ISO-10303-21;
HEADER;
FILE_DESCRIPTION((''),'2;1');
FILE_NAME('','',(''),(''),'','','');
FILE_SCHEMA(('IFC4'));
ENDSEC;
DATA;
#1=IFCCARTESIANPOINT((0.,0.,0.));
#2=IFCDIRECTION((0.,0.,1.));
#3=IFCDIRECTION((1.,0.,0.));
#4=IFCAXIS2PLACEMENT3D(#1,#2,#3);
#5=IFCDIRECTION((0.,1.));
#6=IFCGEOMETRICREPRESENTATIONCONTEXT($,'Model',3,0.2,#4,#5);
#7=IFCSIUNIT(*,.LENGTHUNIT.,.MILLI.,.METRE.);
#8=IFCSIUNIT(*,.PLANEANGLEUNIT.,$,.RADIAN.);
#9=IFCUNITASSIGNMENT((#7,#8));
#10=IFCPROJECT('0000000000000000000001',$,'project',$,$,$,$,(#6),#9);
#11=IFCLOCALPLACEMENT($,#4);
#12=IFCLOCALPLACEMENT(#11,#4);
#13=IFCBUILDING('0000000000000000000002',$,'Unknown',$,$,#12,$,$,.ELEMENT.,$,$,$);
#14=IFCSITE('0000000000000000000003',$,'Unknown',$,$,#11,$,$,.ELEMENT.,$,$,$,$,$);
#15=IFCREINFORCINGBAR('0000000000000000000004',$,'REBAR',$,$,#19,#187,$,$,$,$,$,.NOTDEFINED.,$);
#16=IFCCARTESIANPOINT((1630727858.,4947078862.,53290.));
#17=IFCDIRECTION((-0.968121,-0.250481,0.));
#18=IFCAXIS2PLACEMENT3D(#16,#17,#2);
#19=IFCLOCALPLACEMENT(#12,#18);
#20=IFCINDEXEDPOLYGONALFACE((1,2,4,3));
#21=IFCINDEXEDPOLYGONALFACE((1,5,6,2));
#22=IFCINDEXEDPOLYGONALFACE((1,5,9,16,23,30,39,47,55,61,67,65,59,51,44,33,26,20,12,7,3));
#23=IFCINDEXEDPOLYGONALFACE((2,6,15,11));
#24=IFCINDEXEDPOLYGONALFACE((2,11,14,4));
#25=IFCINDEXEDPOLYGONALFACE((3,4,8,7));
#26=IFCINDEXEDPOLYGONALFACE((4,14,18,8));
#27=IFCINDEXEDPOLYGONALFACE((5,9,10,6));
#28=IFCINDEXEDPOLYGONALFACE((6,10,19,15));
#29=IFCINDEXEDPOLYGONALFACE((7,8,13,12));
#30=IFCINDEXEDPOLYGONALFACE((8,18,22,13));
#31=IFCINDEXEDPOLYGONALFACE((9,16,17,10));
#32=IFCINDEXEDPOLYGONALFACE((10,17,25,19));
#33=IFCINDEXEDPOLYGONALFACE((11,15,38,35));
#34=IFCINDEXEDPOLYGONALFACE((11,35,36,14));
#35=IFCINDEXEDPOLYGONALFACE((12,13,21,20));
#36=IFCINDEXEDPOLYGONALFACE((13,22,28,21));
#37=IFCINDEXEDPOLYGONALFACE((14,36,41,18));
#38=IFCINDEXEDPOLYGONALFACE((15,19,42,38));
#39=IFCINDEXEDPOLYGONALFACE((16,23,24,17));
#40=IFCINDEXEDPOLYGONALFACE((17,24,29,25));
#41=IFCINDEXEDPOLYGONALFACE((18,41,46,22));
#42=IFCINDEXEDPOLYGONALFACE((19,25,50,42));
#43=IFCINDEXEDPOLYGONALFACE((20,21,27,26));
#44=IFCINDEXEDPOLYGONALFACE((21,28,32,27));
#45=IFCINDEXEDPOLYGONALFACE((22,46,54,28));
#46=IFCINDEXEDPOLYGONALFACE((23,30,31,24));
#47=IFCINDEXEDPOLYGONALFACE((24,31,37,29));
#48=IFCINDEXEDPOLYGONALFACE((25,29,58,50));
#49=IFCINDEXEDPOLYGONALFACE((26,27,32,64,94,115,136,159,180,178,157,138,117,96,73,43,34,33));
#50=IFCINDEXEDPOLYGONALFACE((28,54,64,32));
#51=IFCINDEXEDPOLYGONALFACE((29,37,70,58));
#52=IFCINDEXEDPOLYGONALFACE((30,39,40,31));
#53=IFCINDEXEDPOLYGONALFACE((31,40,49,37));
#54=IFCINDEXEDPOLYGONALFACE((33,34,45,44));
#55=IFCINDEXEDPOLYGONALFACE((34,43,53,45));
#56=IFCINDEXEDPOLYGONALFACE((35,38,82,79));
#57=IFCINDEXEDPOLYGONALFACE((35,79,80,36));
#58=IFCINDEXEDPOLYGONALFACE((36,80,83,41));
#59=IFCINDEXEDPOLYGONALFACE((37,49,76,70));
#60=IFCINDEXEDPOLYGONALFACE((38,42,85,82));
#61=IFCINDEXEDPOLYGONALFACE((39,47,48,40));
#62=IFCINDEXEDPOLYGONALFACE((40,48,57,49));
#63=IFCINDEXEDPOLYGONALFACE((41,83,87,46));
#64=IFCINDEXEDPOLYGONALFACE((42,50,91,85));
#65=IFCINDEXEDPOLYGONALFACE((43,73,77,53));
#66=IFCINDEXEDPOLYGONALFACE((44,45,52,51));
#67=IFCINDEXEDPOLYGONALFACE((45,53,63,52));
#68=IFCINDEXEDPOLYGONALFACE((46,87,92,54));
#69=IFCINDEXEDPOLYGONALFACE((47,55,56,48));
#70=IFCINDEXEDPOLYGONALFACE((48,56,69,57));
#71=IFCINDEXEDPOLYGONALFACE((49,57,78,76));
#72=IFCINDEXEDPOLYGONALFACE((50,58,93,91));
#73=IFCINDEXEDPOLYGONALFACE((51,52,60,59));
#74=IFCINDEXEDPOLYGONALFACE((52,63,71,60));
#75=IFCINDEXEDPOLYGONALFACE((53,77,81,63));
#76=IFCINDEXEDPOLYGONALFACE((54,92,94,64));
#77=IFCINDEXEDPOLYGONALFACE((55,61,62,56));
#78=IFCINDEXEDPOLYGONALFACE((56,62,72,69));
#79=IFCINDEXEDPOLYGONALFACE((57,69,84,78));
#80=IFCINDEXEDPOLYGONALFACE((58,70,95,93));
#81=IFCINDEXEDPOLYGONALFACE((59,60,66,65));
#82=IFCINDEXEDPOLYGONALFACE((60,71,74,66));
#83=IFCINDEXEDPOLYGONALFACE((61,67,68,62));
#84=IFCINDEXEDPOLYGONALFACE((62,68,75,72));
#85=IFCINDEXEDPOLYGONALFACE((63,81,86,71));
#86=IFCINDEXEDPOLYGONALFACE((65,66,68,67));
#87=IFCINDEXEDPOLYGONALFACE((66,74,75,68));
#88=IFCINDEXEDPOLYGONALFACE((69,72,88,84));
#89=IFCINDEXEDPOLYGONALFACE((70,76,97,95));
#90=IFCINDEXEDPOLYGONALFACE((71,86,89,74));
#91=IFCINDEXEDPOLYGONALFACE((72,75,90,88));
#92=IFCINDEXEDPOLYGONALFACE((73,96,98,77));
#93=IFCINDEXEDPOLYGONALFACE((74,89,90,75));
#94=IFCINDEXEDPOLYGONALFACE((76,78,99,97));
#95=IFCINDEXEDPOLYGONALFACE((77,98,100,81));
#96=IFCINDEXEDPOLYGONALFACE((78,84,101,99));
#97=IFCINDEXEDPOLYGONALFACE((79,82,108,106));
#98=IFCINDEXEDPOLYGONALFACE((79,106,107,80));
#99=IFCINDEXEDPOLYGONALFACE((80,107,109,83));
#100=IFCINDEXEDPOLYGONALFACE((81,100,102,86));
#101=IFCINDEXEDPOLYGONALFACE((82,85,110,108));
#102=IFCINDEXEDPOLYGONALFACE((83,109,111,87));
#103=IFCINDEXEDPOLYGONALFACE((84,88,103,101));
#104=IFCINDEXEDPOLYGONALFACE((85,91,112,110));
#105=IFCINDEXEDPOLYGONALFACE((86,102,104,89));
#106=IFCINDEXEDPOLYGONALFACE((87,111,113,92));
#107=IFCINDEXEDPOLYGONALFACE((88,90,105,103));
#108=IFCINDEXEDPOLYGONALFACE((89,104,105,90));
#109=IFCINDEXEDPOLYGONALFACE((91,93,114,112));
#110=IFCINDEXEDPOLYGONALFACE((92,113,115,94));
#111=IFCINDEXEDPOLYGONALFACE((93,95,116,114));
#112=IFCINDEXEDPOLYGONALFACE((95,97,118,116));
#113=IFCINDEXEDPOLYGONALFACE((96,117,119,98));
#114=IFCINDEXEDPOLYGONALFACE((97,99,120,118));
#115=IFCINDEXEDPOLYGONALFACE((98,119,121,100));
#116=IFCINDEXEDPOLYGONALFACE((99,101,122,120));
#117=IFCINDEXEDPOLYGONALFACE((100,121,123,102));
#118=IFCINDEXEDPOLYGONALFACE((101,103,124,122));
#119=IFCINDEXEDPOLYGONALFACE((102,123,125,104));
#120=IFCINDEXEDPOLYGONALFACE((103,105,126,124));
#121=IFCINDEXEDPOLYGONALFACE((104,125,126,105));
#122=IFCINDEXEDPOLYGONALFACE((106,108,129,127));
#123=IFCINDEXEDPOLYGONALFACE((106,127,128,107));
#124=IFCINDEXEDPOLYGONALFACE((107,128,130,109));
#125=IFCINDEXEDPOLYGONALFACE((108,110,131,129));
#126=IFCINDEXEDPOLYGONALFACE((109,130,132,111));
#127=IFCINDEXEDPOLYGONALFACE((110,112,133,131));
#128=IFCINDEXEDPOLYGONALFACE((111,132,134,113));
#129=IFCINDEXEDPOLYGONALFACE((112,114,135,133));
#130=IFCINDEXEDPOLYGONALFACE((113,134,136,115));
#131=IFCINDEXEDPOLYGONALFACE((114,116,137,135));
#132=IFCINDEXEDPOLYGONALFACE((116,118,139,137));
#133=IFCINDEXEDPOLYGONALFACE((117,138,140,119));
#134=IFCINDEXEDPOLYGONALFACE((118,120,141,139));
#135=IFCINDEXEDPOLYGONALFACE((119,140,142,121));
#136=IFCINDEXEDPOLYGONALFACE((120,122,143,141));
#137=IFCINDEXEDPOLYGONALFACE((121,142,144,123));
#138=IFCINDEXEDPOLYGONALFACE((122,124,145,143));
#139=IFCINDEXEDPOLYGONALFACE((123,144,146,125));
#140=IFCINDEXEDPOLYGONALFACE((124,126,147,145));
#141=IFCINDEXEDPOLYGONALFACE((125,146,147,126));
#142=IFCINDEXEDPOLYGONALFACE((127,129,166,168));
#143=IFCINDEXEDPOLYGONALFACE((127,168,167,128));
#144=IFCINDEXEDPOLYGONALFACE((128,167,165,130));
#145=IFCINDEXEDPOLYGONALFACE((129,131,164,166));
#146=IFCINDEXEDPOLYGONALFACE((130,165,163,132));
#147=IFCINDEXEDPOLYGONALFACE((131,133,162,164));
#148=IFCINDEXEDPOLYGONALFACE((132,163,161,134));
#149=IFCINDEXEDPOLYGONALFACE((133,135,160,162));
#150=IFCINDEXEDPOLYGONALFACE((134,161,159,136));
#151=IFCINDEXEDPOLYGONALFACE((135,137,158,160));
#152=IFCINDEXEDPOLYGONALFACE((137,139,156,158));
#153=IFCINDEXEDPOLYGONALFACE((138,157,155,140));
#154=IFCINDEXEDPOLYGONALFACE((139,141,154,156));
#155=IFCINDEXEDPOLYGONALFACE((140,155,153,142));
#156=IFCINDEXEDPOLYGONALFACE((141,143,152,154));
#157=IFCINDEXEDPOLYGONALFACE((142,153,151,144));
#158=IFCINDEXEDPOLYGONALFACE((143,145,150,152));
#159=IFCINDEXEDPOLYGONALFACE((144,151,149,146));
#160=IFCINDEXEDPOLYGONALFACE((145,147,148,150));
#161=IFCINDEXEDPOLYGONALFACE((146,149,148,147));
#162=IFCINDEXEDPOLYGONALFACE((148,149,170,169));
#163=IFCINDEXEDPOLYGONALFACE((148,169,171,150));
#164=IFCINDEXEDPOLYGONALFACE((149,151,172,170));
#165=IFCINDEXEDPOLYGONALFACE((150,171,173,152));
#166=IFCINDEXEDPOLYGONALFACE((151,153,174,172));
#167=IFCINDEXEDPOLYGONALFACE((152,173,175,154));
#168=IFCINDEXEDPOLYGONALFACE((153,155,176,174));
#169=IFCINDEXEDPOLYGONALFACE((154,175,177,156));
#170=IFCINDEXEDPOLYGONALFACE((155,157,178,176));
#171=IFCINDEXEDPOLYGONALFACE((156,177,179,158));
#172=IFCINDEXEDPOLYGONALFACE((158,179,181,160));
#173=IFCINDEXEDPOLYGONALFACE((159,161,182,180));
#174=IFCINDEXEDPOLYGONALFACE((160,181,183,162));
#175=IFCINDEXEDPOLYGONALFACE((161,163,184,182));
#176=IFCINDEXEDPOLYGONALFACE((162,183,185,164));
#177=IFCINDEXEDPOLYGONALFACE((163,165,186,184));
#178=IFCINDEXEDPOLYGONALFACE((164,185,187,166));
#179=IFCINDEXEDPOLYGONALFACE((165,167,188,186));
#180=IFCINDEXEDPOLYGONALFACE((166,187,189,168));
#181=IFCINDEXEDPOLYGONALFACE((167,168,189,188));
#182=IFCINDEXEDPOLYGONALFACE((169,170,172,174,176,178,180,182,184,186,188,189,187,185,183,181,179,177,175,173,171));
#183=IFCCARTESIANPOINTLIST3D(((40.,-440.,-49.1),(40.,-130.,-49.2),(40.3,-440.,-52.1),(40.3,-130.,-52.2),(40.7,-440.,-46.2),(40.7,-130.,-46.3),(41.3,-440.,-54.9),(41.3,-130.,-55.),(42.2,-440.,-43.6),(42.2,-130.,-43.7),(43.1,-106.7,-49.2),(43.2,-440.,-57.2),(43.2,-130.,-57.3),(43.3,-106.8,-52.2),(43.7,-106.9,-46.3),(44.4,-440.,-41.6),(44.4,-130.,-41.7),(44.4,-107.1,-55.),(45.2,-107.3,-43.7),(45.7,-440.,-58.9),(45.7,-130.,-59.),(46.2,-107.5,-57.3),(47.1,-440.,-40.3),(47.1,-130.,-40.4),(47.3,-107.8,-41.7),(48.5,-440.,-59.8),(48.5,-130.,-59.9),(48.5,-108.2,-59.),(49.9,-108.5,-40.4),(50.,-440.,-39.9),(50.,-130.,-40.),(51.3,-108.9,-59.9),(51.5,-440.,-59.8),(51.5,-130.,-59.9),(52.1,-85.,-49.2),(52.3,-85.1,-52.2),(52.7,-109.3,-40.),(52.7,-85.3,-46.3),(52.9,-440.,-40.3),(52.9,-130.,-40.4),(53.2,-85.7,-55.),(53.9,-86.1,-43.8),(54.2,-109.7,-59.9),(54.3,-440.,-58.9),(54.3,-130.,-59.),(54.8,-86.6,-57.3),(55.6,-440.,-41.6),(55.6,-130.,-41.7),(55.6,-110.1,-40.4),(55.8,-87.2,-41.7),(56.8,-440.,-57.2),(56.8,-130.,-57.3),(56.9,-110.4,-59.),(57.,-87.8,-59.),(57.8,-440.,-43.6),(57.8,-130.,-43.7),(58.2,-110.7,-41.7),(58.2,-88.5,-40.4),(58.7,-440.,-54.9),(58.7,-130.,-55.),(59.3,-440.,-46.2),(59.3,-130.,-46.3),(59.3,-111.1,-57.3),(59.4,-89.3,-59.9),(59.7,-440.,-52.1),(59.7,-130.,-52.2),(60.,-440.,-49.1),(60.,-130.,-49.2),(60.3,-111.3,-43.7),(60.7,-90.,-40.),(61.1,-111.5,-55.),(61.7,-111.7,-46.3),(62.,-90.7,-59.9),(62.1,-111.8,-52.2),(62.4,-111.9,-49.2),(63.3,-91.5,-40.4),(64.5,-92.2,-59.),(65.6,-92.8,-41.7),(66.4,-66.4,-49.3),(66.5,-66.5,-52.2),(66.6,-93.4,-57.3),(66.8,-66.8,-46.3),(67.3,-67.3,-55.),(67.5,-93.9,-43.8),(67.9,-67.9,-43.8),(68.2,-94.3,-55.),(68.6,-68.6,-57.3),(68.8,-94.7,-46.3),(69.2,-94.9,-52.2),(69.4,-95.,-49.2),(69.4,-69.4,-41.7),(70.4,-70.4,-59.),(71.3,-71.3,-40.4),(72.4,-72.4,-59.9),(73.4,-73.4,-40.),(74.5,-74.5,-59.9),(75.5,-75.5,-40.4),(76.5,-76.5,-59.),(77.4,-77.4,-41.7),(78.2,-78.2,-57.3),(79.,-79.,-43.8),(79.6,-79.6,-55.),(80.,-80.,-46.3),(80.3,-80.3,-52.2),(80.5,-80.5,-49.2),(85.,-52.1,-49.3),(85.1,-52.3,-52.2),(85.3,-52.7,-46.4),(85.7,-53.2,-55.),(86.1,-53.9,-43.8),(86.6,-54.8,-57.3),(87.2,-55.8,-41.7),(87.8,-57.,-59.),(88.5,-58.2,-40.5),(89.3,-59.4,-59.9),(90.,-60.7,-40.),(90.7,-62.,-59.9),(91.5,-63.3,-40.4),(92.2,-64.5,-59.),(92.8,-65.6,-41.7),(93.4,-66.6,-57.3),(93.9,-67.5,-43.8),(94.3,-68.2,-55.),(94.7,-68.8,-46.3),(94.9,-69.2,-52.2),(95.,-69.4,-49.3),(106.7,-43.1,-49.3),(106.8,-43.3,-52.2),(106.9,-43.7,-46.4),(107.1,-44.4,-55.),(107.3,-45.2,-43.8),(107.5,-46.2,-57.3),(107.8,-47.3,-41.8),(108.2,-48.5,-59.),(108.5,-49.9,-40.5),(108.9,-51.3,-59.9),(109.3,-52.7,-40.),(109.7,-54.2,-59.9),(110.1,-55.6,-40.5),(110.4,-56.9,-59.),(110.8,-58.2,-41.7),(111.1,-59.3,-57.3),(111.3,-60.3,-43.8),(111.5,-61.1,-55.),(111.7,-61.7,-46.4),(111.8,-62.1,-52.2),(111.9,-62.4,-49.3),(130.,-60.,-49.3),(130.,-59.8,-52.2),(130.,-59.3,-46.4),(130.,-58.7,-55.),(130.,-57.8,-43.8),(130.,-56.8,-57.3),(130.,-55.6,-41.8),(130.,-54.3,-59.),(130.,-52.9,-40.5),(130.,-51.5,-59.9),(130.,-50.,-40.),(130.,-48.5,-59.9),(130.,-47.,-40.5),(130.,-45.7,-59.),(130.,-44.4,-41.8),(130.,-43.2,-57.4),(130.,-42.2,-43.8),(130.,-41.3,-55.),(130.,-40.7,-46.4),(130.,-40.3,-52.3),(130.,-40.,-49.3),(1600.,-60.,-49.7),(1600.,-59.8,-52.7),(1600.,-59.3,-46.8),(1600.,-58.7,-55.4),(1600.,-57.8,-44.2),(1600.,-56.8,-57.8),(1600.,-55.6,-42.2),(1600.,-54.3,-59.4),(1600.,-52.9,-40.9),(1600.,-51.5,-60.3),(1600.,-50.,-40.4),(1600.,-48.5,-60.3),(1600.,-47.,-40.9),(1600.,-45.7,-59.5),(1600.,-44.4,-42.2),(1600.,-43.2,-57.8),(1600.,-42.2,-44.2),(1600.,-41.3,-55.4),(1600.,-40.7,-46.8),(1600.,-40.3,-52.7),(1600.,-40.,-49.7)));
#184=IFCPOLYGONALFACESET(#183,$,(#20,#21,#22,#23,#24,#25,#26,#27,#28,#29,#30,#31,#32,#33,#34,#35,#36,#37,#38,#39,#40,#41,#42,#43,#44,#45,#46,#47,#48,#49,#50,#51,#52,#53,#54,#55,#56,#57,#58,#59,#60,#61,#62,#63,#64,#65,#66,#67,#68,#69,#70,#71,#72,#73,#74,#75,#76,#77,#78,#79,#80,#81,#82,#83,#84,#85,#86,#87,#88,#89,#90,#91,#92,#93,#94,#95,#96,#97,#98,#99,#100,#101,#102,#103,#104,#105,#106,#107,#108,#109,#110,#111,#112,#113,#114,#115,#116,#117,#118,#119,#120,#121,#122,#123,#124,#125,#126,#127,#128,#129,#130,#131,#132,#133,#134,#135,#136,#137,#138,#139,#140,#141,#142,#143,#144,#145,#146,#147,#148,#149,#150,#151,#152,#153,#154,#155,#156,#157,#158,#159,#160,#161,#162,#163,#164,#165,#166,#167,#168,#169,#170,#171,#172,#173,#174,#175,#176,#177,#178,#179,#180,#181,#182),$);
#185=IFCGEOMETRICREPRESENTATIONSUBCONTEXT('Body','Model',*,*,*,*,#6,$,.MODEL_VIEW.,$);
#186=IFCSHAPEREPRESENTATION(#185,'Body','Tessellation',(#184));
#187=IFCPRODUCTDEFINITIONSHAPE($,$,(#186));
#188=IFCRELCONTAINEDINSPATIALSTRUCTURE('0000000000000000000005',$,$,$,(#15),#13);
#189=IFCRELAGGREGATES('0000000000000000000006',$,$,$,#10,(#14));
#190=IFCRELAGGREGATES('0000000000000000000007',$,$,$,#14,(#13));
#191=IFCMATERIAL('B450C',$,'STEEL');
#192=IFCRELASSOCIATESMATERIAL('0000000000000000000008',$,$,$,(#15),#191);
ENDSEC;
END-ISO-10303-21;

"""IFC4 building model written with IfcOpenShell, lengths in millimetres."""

from ifc_helpers import new_model, entity, si_unit, direction, frame, origin_with_axes, place, context, subcontext, project, spatial, material, element, save


model = new_model("IFC4")

# Units and contexts
model_context = context("Model", 3, precision=0.2, world=origin_with_axes(), true_north=direction((0.0, 1.0)))
body_context = subcontext(model_context, "Body", "Model", "MODEL_VIEW")
ifc_project = project(units=[si_unit("LENGTHUNIT", "METRE", prefix="MILLI"), si_unit("PLANEANGLEUNIT", "RADIAN")], contexts=[model_context])

# Site, building
site_placement = place(None, origin_with_axes())
site = spatial("IfcSite", under=ifc_project, at=site_placement, Name="Unknown", CompositionType="ELEMENT")
building_placement = place(site_placement, origin_with_axes())
building = spatial("IfcBuilding", under=site, at=building_placement, Name="Unknown", CompositionType="ELEMENT")

# Reinforcing bar
ifc_material = material(Name="B450C", Category="STEEL")
reinforcing_bar_1_placement = place(building_placement, frame((1630727858.0, 4947078862.0, 53290.0), z_axis=(-0.968121, -0.250481, 0.0), x_axis=(0.0, 0.0, 1.0)))
element("IfcReinforcingBar", 1, at=reinforcing_bar_1_placement, inside=building, material=ifc_material, Name="REBAR", PredefinedType="NOTDEFINED", context=body_context, shape_type="AdvancedSweptSolid", body=[
    entity("IfcSweptDiskSolid", entity("IfcIndexedPolyCurve", entity("IfcCartesianPointList3D", [[50.0, -440.0, -49.9], [50.0, -130.0, -50.0], [73.4, -73.4, -50.0], [130.0, -50.0, -50.0], [1600.0, -50.0, -50.4]]), [entity("IfcLineIndex", [1, 2]), entity("IfcArcIndex", [2, 3, 4]), entity("IfcLineIndex", [4, 5])]), 10.0),
])

save(model, "model.ifc")
